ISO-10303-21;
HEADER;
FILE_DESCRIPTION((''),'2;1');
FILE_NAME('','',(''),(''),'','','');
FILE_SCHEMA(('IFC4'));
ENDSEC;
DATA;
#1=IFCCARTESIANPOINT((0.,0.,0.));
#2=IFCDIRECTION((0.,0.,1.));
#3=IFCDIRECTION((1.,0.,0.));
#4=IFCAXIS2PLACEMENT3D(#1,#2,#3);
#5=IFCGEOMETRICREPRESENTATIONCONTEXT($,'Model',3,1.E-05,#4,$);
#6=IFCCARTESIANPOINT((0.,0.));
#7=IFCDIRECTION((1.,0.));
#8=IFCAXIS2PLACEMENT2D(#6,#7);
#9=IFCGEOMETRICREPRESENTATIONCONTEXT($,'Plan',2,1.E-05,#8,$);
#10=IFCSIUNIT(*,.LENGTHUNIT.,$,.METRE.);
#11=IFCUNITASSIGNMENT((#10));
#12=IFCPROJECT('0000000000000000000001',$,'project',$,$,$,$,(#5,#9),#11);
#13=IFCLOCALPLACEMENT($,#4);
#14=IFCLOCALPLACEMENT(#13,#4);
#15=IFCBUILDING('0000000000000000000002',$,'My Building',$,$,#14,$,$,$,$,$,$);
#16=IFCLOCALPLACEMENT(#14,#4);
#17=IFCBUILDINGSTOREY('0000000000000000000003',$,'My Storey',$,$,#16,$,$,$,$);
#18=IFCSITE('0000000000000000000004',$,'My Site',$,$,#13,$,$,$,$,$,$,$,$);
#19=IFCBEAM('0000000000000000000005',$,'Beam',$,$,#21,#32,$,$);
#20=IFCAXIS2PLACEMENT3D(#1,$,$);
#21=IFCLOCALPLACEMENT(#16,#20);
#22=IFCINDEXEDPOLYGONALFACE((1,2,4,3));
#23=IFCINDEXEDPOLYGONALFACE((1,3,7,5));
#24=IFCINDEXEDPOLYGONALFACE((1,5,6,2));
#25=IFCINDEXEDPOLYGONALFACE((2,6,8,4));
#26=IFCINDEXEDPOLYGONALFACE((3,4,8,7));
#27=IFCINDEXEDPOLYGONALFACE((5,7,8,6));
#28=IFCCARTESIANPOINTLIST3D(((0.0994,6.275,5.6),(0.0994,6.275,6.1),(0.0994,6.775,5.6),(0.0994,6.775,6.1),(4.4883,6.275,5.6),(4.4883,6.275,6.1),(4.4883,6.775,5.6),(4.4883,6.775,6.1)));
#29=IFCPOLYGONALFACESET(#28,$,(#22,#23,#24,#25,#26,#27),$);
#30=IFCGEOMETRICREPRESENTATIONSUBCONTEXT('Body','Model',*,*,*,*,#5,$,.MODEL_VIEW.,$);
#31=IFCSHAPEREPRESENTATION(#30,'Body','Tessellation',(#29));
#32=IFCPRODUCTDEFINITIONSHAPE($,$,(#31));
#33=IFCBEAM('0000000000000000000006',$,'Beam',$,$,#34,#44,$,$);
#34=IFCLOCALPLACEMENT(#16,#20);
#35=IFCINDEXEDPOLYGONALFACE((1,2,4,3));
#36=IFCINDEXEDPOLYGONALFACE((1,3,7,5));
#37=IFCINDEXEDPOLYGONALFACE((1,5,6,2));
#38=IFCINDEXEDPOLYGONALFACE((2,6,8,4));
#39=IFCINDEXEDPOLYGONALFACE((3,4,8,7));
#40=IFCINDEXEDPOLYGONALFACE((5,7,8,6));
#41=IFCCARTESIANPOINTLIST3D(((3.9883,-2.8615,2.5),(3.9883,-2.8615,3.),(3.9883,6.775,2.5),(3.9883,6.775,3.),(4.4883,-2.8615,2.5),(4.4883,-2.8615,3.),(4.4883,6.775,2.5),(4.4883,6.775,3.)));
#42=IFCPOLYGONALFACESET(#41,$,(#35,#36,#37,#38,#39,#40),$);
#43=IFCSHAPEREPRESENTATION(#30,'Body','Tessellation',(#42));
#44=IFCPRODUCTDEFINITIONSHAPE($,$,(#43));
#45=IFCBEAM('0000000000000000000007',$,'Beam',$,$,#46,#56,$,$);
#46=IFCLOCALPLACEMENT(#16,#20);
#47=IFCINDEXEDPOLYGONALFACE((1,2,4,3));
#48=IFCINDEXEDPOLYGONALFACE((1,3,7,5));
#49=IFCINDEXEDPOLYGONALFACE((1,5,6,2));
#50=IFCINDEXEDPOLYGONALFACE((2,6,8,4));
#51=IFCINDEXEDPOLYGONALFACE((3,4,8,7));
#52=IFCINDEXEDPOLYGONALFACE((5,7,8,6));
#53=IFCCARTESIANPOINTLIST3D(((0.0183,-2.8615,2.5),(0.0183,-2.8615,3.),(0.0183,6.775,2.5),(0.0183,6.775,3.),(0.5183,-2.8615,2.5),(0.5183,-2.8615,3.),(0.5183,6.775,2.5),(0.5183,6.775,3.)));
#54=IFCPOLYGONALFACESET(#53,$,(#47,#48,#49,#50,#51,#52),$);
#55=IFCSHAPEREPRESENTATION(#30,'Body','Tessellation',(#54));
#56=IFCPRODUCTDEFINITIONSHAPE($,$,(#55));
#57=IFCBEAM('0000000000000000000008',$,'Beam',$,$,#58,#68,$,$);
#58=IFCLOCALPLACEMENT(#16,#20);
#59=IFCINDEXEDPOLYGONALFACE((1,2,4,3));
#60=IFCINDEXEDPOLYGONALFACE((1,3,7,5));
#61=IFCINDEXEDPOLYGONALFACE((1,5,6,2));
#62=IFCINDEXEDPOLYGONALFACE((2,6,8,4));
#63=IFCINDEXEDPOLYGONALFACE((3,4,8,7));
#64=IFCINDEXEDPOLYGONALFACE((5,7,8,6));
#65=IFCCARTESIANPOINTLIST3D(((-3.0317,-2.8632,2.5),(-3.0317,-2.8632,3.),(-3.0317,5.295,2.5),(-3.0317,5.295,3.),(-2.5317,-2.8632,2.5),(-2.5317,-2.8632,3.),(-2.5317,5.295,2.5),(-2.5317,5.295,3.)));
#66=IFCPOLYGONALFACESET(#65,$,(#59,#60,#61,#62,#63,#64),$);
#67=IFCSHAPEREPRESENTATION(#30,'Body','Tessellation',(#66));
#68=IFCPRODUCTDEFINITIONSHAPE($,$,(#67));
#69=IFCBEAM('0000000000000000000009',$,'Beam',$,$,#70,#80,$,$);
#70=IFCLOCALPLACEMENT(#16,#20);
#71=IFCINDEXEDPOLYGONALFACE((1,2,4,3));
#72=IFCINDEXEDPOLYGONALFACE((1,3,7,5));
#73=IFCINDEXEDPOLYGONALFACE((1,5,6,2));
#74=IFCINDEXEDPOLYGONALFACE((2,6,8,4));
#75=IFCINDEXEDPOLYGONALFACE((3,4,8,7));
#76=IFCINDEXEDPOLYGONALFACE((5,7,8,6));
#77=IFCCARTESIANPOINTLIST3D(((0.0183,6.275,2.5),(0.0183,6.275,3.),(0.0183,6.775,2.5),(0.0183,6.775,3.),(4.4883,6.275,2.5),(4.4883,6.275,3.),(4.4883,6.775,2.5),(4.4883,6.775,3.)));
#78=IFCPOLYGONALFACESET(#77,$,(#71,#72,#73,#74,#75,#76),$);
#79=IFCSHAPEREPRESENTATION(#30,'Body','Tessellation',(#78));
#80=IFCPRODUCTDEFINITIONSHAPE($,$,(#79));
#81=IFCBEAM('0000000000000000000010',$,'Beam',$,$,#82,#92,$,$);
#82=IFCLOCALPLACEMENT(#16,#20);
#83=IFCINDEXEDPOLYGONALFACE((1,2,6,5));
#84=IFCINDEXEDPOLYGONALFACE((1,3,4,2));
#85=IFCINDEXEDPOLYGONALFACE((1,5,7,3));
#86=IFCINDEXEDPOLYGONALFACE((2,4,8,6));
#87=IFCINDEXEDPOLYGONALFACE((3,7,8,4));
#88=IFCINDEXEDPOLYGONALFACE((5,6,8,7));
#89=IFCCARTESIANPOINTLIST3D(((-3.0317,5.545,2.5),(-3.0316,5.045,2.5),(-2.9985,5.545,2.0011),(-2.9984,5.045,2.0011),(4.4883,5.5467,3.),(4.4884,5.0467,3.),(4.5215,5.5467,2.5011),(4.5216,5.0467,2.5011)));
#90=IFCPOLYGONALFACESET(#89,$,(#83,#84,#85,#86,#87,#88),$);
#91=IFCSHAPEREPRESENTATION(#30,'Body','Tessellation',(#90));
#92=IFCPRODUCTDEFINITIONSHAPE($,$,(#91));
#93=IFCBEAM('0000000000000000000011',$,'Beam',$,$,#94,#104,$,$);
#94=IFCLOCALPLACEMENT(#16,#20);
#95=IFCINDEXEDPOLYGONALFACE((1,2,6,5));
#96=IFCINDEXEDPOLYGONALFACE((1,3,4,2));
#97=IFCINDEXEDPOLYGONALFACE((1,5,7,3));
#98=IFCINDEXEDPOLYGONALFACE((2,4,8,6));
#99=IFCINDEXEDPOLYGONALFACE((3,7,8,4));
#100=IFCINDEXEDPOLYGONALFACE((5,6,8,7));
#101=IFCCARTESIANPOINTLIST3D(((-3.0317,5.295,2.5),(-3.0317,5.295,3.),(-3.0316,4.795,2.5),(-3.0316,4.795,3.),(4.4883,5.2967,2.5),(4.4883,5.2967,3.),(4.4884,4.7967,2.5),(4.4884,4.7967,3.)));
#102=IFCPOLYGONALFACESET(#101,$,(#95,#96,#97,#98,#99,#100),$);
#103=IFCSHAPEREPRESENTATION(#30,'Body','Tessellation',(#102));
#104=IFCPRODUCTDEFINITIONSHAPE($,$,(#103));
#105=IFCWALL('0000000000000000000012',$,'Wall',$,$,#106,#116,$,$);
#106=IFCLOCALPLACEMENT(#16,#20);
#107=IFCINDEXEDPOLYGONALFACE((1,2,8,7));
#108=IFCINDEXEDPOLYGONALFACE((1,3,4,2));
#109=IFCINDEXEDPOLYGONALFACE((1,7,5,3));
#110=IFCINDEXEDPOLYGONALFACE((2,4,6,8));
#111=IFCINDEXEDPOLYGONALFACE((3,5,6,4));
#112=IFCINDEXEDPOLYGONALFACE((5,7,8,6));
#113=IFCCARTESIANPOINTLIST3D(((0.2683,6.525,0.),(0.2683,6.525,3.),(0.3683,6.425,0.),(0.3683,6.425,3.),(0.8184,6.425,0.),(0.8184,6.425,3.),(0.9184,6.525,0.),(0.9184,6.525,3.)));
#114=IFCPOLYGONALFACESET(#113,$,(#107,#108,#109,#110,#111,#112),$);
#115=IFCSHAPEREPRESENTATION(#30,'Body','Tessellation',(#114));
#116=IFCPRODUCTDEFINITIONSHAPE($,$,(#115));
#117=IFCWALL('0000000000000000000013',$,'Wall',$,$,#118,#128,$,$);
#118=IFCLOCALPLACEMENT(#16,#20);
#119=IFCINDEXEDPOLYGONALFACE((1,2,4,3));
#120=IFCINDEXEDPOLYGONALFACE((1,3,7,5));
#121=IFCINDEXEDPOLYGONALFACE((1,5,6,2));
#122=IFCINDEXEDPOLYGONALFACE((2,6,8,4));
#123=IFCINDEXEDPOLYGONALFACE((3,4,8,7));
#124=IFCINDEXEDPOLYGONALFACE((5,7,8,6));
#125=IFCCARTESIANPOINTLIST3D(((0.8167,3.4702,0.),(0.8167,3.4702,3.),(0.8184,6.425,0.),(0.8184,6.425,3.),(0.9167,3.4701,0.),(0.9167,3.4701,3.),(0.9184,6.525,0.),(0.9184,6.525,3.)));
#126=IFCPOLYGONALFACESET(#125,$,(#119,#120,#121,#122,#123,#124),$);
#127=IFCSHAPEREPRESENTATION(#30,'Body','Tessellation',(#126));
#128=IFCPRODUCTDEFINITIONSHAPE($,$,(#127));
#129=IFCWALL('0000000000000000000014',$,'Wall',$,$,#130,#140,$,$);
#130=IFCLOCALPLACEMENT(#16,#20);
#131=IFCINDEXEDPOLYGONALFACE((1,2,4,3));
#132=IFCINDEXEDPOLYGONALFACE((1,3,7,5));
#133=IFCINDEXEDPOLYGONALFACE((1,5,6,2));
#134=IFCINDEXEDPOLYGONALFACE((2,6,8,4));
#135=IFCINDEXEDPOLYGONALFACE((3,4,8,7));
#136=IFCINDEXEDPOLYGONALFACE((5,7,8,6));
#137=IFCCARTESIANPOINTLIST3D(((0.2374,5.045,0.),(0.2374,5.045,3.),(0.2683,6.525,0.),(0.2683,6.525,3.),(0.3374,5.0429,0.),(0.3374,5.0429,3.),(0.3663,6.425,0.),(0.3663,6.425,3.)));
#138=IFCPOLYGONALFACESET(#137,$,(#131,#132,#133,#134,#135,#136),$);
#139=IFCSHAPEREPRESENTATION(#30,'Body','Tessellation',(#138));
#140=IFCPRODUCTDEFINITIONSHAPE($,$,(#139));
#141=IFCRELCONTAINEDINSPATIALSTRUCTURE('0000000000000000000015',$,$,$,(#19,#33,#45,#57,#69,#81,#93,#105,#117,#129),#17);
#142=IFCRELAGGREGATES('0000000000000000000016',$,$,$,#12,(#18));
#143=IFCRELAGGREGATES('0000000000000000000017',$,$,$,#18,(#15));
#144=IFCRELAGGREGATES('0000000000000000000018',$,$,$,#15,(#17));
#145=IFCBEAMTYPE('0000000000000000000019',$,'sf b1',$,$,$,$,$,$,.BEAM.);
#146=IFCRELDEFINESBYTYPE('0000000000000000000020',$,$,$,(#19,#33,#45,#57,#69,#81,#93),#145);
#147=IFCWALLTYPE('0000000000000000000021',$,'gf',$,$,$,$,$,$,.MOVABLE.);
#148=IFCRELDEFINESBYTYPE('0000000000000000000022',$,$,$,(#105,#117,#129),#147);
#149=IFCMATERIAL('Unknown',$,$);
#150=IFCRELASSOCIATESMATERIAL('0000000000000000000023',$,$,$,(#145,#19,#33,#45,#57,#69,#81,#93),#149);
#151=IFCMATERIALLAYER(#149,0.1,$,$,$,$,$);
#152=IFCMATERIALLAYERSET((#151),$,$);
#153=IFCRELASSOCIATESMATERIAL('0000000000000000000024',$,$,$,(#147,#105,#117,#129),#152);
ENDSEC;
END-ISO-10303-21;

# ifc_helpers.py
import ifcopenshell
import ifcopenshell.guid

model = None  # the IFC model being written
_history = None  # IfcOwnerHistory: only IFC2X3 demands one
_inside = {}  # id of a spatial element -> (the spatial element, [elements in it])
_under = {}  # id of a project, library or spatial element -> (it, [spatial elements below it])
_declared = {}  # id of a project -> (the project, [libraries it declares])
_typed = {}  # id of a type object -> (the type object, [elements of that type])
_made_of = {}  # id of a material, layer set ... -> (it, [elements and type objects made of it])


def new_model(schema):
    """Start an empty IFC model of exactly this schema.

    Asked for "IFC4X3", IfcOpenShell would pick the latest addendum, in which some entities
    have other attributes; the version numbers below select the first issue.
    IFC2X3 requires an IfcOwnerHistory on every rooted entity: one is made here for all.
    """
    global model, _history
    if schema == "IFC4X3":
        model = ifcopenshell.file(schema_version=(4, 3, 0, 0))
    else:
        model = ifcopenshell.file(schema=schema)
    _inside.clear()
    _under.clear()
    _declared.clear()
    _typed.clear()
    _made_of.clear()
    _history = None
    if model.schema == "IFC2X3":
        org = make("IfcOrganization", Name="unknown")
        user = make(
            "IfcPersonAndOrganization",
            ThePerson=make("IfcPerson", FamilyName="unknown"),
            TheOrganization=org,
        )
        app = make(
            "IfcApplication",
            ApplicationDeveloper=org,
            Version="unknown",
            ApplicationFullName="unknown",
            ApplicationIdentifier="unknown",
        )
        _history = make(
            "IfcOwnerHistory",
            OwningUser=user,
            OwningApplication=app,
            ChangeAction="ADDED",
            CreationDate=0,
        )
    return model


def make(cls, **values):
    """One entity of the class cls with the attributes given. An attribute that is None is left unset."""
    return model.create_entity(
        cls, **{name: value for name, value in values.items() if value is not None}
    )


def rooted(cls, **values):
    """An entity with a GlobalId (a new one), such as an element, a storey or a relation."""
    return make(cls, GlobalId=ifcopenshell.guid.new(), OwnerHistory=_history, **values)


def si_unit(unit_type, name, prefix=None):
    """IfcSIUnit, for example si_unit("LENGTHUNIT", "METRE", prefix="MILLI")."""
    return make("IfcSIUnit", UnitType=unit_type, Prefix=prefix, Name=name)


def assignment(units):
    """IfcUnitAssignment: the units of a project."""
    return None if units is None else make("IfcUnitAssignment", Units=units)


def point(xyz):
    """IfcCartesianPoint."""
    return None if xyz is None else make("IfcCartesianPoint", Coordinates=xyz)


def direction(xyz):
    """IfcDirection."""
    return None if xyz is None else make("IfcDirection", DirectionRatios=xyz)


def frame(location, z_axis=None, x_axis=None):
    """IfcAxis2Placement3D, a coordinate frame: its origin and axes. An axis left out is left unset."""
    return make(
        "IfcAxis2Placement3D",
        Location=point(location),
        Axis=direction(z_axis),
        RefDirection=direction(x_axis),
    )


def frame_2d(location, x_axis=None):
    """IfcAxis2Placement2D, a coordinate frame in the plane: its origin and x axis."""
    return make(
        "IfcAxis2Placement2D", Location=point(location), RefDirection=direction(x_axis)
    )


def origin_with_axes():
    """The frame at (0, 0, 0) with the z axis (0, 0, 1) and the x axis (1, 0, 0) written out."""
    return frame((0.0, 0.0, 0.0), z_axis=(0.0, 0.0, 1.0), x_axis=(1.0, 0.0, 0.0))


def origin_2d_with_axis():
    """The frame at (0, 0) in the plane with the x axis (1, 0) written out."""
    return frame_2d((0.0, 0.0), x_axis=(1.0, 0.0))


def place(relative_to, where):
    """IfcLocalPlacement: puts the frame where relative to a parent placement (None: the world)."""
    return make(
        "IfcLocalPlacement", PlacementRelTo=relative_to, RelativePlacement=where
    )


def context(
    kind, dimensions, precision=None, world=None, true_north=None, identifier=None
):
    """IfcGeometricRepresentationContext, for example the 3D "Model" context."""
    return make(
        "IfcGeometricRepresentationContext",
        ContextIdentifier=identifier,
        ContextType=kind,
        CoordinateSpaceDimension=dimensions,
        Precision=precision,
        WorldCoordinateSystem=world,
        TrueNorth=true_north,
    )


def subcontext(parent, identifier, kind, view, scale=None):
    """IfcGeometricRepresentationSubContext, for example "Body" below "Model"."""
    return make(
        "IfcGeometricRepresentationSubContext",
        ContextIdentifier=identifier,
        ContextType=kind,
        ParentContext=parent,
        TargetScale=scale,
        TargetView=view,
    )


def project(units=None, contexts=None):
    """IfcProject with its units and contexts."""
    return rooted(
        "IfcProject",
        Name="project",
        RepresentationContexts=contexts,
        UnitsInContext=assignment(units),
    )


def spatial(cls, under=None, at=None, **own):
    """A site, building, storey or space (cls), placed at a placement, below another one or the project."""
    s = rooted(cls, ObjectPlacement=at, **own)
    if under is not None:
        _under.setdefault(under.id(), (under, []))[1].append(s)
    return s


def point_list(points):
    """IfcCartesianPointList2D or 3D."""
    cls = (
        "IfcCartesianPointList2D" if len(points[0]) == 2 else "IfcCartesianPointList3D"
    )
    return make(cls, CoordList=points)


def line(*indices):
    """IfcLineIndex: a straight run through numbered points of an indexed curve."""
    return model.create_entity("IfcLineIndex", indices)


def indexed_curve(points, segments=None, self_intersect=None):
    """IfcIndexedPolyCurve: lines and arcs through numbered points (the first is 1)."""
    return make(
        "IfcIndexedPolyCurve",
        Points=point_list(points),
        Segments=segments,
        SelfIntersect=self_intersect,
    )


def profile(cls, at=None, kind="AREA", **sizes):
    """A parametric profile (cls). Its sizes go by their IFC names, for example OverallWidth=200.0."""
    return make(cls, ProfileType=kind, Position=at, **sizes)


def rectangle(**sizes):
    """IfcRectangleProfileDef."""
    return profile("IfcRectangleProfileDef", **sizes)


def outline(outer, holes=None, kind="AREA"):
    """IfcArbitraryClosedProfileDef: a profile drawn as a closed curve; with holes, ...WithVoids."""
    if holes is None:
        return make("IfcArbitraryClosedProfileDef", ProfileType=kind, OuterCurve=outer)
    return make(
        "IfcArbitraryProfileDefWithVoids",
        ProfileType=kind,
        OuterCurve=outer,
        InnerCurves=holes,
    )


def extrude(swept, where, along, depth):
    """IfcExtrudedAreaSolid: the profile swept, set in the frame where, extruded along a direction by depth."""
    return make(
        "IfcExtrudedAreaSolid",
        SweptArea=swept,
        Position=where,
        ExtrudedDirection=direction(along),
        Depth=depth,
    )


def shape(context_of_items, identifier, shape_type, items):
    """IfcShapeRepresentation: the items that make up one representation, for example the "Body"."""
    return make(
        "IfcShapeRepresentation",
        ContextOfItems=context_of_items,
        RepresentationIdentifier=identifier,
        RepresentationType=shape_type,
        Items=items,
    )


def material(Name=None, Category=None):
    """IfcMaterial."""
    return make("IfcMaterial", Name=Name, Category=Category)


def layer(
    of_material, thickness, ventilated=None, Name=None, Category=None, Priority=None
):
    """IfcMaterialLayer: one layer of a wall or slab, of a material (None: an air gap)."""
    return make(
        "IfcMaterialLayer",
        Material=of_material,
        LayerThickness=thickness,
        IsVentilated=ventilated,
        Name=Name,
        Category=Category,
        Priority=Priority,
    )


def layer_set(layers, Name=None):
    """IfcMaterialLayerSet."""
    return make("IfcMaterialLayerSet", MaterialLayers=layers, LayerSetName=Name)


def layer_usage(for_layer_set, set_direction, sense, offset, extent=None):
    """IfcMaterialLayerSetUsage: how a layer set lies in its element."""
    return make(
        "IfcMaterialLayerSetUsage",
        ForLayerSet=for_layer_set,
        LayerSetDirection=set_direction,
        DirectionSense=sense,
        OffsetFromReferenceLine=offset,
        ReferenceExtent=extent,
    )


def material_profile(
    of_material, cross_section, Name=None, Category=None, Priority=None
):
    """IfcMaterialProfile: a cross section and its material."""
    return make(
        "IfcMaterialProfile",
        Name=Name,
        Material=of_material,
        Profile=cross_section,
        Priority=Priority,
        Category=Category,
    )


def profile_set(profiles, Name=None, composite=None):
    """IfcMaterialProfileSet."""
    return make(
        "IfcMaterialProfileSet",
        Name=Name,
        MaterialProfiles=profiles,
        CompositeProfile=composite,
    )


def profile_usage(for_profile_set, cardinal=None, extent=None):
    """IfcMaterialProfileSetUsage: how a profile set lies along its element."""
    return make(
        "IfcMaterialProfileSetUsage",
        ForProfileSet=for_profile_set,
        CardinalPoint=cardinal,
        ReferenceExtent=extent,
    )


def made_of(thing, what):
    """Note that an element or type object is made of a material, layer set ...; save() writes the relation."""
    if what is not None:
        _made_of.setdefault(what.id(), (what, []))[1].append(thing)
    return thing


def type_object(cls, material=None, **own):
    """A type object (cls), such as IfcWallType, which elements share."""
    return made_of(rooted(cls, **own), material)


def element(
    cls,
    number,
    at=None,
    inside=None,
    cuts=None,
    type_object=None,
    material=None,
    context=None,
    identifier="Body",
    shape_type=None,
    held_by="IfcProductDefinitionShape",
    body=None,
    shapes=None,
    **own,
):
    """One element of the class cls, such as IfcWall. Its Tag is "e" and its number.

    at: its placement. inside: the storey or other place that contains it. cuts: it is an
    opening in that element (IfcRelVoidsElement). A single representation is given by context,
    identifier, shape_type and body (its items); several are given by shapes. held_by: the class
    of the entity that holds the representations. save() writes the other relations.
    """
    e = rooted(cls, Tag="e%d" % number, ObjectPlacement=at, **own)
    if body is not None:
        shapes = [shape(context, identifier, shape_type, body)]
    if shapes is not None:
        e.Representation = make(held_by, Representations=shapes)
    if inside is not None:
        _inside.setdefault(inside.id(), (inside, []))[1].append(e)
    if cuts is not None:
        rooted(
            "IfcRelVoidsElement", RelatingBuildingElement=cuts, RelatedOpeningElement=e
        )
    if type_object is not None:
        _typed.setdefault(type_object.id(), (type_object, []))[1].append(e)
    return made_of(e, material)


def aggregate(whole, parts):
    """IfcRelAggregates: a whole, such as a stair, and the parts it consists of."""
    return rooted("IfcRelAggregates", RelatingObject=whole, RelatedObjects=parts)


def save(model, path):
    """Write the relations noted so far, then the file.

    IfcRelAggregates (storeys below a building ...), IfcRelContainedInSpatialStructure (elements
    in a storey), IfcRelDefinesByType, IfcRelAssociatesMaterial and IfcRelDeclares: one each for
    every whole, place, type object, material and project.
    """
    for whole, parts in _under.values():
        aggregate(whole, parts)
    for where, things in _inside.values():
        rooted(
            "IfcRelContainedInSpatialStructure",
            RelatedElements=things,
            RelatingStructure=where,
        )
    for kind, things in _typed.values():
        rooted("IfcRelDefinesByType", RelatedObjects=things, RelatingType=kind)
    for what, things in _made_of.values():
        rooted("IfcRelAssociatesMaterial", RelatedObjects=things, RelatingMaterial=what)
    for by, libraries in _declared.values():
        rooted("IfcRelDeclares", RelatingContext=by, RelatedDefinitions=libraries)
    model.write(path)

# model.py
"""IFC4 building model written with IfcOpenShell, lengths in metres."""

from ifc_helpers import new_model, si_unit, frame, origin_with_axes, origin_2d_with_axis, place, context, subcontext, project, spatial, line, indexed_curve, rectangle, outline, extrude, material, layer, layer_set, layer_usage, material_profile, profile_set, profile_usage, type_object, element, save


model = new_model("IFC4")

# Units and contexts
model_context = context("Model", 3, precision=1e-05, world=origin_with_axes())
plan_context = context("Plan", 2, precision=1e-05, world=origin_2d_with_axis())
body_context = subcontext(model_context, "Body", "Model", "MODEL_VIEW")
ifc_project = project(units=[si_unit("LENGTHUNIT", "METRE")], contexts=[model_context, plan_context])

# Site, building, storey
site_placement = place(None, origin_with_axes())
site = spatial("IfcSite", under=ifc_project, at=site_placement, Name="My Site")
building_placement = place(site_placement, origin_with_axes())
building = spatial("IfcBuilding", under=site, at=building_placement, Name="My Building")
storey_placement = place(building_placement, origin_with_axes())
storey = spatial("IfcBuildingStorey", under=building, at=storey_placement, Name="My Storey")

# Shared definitions
ifc_material = material(Name="Unknown")

# Beams
ifc_material_profile_1 = material_profile(ifc_material, rectangle(XDim=0.5, YDim=0.5))
ifc_profile_set_1 = profile_set([ifc_material_profile_1])
beam_type = type_object("IfcBeamType", Name="sf b1", PredefinedType="BEAM", material=ifc_profile_set_1)
ifc_profile_usage_1 = profile_usage(ifc_profile_set_1, cardinal=7)
beam_1_placement = place(storey_placement, frame((0.0994, 6.775, 6.1), z_axis=(1.0, 0.0, 0.0), x_axis=(0.0, 1.0, 0.0)))
element("IfcBeam", 1, at=beam_1_placement, inside=storey, type_object=beam_type, material=ifc_profile_usage_1, Name="Beam", context=body_context, shape_type="SweptSolid", body=[
    extrude(rectangle(XDim=0.5, YDim=0.5), frame((-0.25, -0.25, 0.0), z_axis=(0.0, 0.0, 1.0), x_axis=(1.0, 0.0, 0.0)), (0.0, 0.0, 1.0), 4.389),
])
ifc_profile_usage_2 = profile_usage(ifc_profile_set_1, cardinal=8)
beam_2_placement = place(storey_placement, frame((4.2383, 6.775, 3.0), z_axis=(0.0, -1.0, 0.0), x_axis=(1.0, 0.0, 0.0)))
element("IfcBeam", 2, at=beam_2_placement, inside=storey, type_object=beam_type, material=ifc_profile_usage_2, Name="Beam", context=body_context, shape_type="SweptSolid", body=[
    extrude(rectangle(XDim=0.5, YDim=0.5), frame((0.0, -0.25, 0.0), z_axis=(0.0, 0.0, 1.0), x_axis=(1.0, 0.0, 0.0)), (0.0, 0.0, 1.0), 9.6364),
])
ifc_profile_usage_3 = profile_usage(ifc_profile_set_1, cardinal=8)
beam_3_placement = place(storey_placement, frame((0.2683, 6.775, 3.0), z_axis=(0.0, -1.0, 0.0), x_axis=(1.0, 0.0, 0.0)))
element("IfcBeam", 3, at=beam_3_placement, inside=storey, type_object=beam_type, material=ifc_profile_usage_3, Name="Beam", context=body_context, shape_type="SweptSolid", body=[
    extrude(rectangle(XDim=0.5, YDim=0.5), frame((0.0, -0.25, 0.0), z_axis=(0.0, 0.0, 1.0), x_axis=(1.0, 0.0, 0.0)), (0.0, 0.0, 1.0), 9.6364),
])
ifc_profile_usage_4 = profile_usage(ifc_profile_set_1, cardinal=8)
beam_4_placement = place(storey_placement, frame((-2.7817, 5.295, 3.0), z_axis=(0.0, -1.0, 0.0), x_axis=(1.0, 0.0, 0.0)))
element("IfcBeam", 4, at=beam_4_placement, inside=storey, type_object=beam_type, material=ifc_profile_usage_4, Name="Beam", context=body_context, shape_type="SweptSolid", body=[
    extrude(rectangle(XDim=0.5, YDim=0.5), frame((0.0, -0.25, 0.0), z_axis=(0.0, 0.0, 1.0), x_axis=(1.0, 0.0, 0.0)), (0.0, 0.0, 1.0), 8.1582),
])
ifc_profile_usage_5 = profile_usage(ifc_profile_set_1, cardinal=8)
beam_5_placement = place(storey_placement, frame((4.4883, 6.525, 3.0), z_axis=(-1.0, 0.0, 0.0), x_axis=(0.0, -1.0, 0.0)))
element("IfcBeam", 5, at=beam_5_placement, inside=storey, type_object=beam_type, material=ifc_profile_usage_5, Name="Beam", context=body_context, shape_type="SweptSolid", body=[
    extrude(rectangle(XDim=0.5, YDim=0.5), frame((0.0, -0.25, 0.0), z_axis=(0.0, 0.0, 1.0), x_axis=(1.0, 0.0, 0.0)), (0.0, 0.0, 1.0), 4.47),
])
ifc_profile_usage_6 = profile_usage(ifc_profile_set_1, cardinal=8)
beam_6_placement = place(storey_placement, frame((-3.0317, 5.295, 2.5), z_axis=(0.997797, 0.000228, 0.066343), x_axis=(-0.000228, 1.0, 0.0)))
element("IfcBeam", 6, at=beam_6_placement, inside=storey, type_object=beam_type, material=ifc_profile_usage_6, Name="Beam", context=body_context, shape_type="SweptSolid", body=[
    extrude(rectangle(XDim=0.5, YDim=0.5), frame((0.0, -0.25, 0.0), z_axis=(0.0, 0.0, 1.0), x_axis=(1.0, 0.0, 0.0)), (0.0, 0.0, 1.0), 7.5366),
])
ifc_profile_usage_7 = profile_usage(ifc_profile_set_1, cardinal=8)
beam_7_placement = place(storey_placement, frame((4.4883, 5.0467, 3.0), z_axis=(-1.0, -0.000228, 0.0), x_axis=(0.000228, -1.0, 0.0)))
element("IfcBeam", 7, at=beam_7_placement, inside=storey, type_object=beam_type, material=ifc_profile_usage_7, Name="Beam", context=body_context, shape_type="SweptSolid", body=[
    extrude(rectangle(XDim=0.5, YDim=0.5), frame((0.0, -0.25, 0.0), z_axis=(0.0, 0.0, 1.0), x_axis=(1.0, 0.0, 0.0)), (0.0, 0.0, 1.0), 7.52),
])

# Walls
ifc_layer = layer(ifc_material, 0.1)
ifc_layer_set = layer_set([ifc_layer])
ifc_layer_usage_1 = layer_usage(ifc_layer_set, "AXIS2", "POSITIVE", 0.0)
wall_type = type_object("IfcWallType", Name="gf", PredefinedType="MOVABLE", material=ifc_layer_set)
wall_1_placement = place(storey_placement, frame((0.9184, 6.525, 0.0), z_axis=(0.0, 0.0, 1.0), x_axis=(-1.0, 0.0, 0.0)))
element("IfcWall", 8, at=wall_1_placement, inside=storey, type_object=wall_type, material=ifc_layer_usage_1, Name="Wall", context=body_context, shape_type="SweptSolid", body=[
    extrude(outline(indexed_curve([(0.0, 0.0), (0.1001, 0.1), (0.5501, 0.1), (0.6501, 0.0)], segments=[line(1, 2, 3, 4, 1)])), origin_with_axes(), (0.0, 0.0, 1.0), 3.0),
])
ifc_layer_usage_2 = layer_usage(ifc_layer_set, "AXIS2", "POSITIVE", 0.0)
wall_2_placement = place(storey_placement, frame((0.9167, 3.4701, 0.0), z_axis=(0.0, 0.0, 1.0), x_axis=(0.000578, 1.0, 0.0)))
element("IfcWall", 9, at=wall_2_placement, inside=storey, type_object=wall_type, material=ifc_layer_usage_2, Name="Wall", context=body_context, shape_type="SweptSolid", body=[
    extrude(outline(indexed_curve([(0.0, 0.0), (0.0, 0.1), (2.9548, 0.1), (3.0548, 0.0)], segments=[line(1, 2, 3, 4, 1)])), origin_with_axes(), (0.0, 0.0, 1.0), 3.0),
])
ifc_layer_usage_3 = layer_usage(ifc_layer_set, "AXIS2", "POSITIVE", 0.0)
wall_3_placement = place(storey_placement, frame((0.2683, 6.525, 0.0), z_axis=(0.0, 0.0, 1.0), x_axis=(-0.020906, -0.999781, 0.0)))
element("IfcWall", 10, at=wall_3_placement, inside=storey, type_object=wall_type, material=ifc_layer_usage_3, Name="Wall", context=body_context, shape_type="SweptSolid", body=[
    extrude(outline(indexed_curve([(0.0, 0.0), (0.0979, 0.1), (1.4803, 0.1), (1.4803, 0.0)], segments=[line(1, 2, 3, 4, 1)])), origin_with_axes(), (0.0, 0.0, 1.0), 3.0),
])

save(model, "model.ifc")
